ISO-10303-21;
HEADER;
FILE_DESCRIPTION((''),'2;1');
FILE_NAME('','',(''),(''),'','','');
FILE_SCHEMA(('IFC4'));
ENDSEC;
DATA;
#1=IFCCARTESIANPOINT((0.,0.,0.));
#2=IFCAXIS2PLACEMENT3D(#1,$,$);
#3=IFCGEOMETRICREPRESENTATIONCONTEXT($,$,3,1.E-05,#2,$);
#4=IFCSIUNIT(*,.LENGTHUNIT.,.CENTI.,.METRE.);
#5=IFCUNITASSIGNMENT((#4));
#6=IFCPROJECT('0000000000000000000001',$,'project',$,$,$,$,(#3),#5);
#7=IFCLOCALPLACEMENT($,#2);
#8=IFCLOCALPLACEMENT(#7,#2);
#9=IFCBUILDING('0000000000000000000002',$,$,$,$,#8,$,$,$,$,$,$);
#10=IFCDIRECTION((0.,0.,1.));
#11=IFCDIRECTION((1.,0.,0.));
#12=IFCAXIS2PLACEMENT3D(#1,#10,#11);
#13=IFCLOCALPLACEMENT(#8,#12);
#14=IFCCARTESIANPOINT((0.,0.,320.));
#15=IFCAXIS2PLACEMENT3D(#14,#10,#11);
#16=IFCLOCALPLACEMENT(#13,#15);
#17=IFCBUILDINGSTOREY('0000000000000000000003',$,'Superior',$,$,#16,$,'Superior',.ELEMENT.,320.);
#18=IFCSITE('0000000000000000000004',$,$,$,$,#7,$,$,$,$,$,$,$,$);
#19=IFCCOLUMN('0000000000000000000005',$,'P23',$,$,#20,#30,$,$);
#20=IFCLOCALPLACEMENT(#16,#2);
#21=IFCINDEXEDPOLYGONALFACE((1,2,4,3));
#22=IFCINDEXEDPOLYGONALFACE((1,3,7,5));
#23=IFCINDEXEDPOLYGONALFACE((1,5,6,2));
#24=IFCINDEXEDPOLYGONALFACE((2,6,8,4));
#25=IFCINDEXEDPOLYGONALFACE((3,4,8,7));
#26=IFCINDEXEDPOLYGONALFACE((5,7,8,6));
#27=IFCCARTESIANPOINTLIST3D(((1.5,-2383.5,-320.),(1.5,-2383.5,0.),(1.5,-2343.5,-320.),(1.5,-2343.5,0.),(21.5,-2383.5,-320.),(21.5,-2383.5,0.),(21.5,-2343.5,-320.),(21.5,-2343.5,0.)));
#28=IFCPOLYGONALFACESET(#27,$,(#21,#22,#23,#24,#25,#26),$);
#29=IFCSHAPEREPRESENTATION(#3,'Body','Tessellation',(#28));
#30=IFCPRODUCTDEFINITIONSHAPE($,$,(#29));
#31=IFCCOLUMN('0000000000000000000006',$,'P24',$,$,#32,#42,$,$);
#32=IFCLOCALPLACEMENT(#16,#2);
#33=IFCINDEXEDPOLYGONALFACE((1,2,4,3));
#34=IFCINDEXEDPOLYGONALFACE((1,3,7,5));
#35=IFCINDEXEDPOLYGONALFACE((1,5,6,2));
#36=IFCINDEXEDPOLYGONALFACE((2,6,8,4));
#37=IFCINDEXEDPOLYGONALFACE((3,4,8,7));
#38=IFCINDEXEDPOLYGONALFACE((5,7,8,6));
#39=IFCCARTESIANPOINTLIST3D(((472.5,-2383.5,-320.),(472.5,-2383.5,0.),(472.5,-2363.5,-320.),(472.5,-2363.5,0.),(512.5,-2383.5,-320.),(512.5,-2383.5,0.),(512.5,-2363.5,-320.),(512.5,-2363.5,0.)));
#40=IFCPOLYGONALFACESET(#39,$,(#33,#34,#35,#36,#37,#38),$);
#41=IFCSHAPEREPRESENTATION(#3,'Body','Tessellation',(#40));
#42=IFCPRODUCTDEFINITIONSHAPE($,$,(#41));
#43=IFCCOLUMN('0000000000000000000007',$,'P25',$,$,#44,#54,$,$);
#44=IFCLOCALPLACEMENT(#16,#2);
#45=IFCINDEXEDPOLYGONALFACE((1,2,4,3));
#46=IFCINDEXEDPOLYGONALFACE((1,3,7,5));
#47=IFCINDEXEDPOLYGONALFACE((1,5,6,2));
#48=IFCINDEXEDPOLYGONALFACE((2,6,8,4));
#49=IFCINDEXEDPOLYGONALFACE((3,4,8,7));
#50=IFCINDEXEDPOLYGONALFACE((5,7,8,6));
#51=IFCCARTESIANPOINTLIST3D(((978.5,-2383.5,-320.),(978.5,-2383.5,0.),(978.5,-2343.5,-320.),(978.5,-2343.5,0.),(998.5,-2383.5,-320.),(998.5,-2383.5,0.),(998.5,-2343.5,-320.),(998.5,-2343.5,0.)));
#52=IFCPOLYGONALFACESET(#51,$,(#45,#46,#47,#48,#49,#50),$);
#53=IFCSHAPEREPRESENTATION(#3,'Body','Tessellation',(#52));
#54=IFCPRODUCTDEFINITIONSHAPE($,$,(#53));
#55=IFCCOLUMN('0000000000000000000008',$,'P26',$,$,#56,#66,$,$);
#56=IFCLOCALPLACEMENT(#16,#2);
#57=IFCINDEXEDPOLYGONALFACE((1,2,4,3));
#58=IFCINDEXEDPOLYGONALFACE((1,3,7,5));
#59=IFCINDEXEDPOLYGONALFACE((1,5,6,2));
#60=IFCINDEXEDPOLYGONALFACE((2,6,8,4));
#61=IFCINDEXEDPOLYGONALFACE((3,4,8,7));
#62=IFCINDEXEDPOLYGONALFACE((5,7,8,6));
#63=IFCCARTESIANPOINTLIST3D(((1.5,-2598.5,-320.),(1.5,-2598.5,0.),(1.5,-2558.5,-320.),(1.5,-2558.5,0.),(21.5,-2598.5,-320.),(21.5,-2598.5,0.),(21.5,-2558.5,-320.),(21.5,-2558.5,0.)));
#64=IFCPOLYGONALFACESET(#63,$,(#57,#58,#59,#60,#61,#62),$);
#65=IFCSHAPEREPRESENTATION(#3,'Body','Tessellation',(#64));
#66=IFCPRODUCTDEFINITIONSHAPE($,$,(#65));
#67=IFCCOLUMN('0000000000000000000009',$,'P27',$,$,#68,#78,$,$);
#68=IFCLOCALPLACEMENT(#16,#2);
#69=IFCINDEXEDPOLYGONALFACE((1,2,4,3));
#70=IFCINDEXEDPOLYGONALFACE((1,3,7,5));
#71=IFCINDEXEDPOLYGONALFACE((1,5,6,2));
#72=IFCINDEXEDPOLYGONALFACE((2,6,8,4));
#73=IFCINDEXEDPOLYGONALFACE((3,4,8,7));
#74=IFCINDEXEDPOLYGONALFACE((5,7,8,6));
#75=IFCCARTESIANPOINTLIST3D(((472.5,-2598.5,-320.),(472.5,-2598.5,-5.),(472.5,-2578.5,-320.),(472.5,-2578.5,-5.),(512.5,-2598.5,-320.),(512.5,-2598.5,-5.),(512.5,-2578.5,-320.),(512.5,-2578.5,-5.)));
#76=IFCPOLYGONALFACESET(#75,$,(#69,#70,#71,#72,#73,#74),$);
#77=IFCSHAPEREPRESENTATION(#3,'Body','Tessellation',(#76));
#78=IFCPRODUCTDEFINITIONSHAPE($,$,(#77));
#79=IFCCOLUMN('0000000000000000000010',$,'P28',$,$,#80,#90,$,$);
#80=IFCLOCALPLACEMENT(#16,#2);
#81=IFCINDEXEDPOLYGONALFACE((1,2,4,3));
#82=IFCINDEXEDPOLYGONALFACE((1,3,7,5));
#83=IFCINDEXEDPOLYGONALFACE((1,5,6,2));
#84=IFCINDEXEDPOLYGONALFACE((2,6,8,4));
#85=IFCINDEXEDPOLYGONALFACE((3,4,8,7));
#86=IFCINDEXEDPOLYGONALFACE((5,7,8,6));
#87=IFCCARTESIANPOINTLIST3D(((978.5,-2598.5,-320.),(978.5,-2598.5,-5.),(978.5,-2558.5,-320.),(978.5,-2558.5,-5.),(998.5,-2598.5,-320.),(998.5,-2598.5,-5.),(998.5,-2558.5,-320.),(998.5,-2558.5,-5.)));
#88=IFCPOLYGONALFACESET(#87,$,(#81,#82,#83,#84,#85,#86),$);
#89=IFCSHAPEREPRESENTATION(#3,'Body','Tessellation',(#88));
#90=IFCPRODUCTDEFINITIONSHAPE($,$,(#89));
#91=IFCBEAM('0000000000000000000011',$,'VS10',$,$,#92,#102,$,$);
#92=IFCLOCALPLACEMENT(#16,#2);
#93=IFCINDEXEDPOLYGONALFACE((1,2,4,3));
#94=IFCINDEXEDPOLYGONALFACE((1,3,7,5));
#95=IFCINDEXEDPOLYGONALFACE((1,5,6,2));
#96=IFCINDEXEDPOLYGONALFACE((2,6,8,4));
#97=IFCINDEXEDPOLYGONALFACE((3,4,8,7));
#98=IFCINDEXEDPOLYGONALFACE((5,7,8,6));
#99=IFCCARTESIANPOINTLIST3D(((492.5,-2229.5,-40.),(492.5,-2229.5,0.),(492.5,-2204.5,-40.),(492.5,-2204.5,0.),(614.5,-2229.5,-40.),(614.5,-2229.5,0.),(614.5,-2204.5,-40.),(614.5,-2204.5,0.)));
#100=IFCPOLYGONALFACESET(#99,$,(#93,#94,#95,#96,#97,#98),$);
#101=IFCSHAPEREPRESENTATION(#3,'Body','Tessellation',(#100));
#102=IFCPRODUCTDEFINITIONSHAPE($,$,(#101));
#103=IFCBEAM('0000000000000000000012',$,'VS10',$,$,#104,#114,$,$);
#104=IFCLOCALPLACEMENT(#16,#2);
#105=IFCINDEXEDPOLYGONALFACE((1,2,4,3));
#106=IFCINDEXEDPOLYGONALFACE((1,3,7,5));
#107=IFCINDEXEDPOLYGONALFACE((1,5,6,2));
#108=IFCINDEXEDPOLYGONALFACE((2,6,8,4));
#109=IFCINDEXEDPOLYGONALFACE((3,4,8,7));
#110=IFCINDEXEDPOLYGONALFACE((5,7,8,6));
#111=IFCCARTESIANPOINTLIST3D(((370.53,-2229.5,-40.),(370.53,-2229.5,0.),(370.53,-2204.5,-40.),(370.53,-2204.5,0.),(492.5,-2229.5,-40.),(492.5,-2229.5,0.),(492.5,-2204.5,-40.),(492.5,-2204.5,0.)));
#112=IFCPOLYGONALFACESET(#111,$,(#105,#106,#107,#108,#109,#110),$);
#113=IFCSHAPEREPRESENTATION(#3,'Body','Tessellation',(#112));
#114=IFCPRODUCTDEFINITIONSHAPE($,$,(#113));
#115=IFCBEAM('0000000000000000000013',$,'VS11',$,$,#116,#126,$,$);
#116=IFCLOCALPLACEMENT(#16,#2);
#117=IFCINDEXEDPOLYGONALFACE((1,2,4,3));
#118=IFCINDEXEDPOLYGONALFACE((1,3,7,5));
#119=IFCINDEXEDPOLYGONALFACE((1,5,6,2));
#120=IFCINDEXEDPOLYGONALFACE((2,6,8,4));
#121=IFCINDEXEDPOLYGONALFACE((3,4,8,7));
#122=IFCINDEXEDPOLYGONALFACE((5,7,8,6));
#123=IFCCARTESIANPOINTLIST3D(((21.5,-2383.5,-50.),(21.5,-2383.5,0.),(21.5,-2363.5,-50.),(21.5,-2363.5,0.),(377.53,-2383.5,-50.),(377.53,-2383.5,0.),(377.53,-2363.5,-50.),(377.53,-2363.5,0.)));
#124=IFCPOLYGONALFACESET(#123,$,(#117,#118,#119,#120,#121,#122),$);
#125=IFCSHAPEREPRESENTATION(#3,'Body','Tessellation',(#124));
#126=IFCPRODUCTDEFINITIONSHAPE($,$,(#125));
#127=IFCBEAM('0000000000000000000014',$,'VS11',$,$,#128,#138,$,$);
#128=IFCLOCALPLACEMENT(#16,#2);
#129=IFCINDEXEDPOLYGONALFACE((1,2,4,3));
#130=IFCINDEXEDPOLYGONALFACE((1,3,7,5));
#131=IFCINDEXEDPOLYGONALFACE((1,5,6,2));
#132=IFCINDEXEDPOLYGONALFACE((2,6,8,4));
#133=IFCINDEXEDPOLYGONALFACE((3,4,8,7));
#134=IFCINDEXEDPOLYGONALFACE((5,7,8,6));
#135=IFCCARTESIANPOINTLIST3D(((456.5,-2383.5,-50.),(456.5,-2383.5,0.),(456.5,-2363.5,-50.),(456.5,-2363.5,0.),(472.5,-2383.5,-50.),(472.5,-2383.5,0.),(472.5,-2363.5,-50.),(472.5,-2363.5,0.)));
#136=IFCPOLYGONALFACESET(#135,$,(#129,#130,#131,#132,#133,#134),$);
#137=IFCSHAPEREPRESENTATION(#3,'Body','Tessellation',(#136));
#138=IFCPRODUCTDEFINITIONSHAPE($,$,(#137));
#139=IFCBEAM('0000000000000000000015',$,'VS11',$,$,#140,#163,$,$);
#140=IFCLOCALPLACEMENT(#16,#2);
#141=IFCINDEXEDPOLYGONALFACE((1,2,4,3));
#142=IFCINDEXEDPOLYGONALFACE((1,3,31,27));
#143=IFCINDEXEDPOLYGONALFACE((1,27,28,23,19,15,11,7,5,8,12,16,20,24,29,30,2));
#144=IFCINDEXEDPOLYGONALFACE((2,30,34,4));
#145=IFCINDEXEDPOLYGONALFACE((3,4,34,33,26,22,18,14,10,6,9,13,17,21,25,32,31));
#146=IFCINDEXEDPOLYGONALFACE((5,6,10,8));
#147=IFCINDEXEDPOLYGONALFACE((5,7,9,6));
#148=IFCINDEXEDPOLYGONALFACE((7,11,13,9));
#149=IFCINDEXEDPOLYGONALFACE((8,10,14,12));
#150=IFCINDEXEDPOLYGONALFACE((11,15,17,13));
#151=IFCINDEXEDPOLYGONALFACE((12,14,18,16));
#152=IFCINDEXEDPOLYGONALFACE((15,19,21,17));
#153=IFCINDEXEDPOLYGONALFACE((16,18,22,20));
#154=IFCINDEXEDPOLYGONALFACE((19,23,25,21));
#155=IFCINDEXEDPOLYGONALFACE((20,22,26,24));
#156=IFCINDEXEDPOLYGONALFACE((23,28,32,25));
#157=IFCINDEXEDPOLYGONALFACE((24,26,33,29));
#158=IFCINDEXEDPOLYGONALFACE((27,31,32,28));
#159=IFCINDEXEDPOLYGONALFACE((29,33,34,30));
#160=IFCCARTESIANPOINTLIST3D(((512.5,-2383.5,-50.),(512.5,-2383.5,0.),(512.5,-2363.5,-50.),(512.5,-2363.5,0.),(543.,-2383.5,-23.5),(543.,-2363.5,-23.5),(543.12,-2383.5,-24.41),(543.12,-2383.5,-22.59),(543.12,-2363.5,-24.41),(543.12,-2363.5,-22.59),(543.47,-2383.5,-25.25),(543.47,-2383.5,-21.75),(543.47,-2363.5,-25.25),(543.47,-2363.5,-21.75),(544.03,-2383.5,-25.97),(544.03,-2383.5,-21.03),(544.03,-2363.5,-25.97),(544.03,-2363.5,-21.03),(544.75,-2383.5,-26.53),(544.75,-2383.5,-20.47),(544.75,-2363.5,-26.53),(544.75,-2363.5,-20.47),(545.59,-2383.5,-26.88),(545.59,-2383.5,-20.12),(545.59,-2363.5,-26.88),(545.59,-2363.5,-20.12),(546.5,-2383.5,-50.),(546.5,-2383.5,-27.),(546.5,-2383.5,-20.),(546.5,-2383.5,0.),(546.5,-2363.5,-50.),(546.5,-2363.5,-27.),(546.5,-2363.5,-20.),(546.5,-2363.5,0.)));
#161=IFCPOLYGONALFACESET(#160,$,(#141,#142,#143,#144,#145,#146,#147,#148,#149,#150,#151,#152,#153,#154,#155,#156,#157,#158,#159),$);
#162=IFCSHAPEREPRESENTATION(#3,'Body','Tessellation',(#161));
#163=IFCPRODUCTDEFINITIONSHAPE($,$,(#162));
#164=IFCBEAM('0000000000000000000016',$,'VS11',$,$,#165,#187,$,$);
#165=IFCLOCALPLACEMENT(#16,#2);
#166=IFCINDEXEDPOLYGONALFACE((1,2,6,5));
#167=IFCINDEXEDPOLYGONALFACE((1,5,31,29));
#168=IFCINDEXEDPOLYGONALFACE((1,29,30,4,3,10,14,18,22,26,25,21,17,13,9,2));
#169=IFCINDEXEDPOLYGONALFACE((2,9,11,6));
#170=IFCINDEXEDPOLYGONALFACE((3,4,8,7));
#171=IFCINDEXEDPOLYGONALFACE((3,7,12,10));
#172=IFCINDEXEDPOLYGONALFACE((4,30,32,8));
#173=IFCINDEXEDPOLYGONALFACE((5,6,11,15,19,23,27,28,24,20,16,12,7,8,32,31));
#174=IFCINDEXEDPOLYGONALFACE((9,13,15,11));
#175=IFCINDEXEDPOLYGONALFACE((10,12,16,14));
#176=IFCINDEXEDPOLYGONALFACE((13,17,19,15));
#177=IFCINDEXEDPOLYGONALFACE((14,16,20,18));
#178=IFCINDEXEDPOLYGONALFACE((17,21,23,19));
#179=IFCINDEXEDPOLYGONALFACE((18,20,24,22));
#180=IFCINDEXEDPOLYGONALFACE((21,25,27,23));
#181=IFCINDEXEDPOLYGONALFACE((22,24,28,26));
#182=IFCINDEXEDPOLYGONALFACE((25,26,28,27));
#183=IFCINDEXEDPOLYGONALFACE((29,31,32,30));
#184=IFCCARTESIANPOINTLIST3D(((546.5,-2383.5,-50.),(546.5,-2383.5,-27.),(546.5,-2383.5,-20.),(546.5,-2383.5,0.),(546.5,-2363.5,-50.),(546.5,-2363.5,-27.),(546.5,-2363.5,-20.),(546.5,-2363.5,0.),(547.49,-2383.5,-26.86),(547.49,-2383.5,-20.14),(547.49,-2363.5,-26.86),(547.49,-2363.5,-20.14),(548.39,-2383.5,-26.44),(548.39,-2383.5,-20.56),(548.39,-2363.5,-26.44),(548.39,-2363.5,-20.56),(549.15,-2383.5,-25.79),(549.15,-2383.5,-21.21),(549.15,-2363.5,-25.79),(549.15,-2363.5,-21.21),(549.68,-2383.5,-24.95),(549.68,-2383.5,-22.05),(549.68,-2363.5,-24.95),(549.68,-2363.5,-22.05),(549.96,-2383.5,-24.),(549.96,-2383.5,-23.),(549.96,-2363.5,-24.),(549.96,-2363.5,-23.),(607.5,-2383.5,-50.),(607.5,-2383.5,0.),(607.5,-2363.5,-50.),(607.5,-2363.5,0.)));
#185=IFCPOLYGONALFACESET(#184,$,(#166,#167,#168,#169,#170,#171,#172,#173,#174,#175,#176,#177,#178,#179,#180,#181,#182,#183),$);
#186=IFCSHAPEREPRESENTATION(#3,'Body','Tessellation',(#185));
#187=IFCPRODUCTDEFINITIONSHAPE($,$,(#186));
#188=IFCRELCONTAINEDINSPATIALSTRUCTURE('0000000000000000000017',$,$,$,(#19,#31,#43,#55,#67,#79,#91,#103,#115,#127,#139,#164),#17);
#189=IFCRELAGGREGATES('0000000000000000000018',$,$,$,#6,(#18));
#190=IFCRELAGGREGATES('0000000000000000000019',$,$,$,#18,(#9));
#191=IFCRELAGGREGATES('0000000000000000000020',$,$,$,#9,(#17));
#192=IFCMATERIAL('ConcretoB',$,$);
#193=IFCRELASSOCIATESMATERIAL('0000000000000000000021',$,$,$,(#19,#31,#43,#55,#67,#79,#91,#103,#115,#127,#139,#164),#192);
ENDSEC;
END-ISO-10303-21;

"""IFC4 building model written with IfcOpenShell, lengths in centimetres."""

from ifc_helpers import new_model, si_unit, frame, origin, origin_with_axes, origin_2d_with_axis, place, context, project, spatial, polyline, circle, outline, extrude, material, element, save


model = new_model("IFC4")

# Units and contexts
context_of_model = context(None, 3, precision=1e-05, world=origin())
ifc_project = project(units=[si_unit("LENGTHUNIT", "METRE", prefix="CENTI")], contexts=[context_of_model])

# Site, building, storey
site_placement = place(None, origin())
site = spatial("IfcSite", under=ifc_project, at=site_placement)
building_placement = place(site_placement, origin())
building = spatial("IfcBuilding", under=site, at=building_placement)
placement = place(building_placement, origin_with_axes())
storey_placement = place(placement, frame((0.0, 0.0, 320.0), z_axis=(0.0, 0.0, 1.0), x_axis=(1.0, 0.0, 0.0)))
storey = spatial("IfcBuildingStorey", under=building, at=storey_placement, Name="Superior", LongName="Superior", CompositionType="ELEMENT", Elevation=320.0)

# Columns
ifc_material = material(Name="ConcretoB")
column_1_placement = place(storey_placement, frame((11.5, -2363.5, 0.0), z_axis=(0.0, 0.0, 1.0), x_axis=(1.0, 0.0, 0.0)))
element("IfcColumn", 1, at=column_1_placement, inside=storey, material=ifc_material, Name="P23", context=context_of_model, shape_type="SolidModel", body=[
    extrude(outline(polyline([(-10.0, -20.0), (10.0, -20.0), (10.0, 20.0), (-10.0, 20.0), (-10.0, -20.0)])), frame((0.0, 0.0, 0.0), z_axis=(0.0, 0.0, 1.0), x_axis=(1.0, 0.0, 0.0)), (0.0, 0.0, -1.0), 320.0),
])
column_2_placement = place(storey_placement, frame((492.5, -2373.5, 0.0), z_axis=(0.0, 0.0, 1.0), x_axis=(1.0, 0.0, 0.0)))
element("IfcColumn", 2, at=column_2_placement, inside=storey, material=ifc_material, Name="P24", context=context_of_model, shape_type="SolidModel", body=[
    extrude(outline(polyline([(-20.0, 10.0), (-20.0, -10.0), (20.0, -10.0), (20.0, 10.0), (-20.0, 10.0)])), origin_with_axes(), (0.0, 0.0, -1.0), 320.0),
])
column_3_placement = place(storey_placement, frame((988.5, -2363.5, 0.0), z_axis=(0.0, 0.0, 1.0), x_axis=(1.0, 0.0, 0.0)))
element("IfcColumn", 3, at=column_3_placement, inside=storey, material=ifc_material, Name="P25", context=context_of_model, shape_type="SolidModel", body=[
    extrude(outline(polyline([(10.0, 20.0), (-10.0, 20.0), (-10.0, -20.0), (10.0, -20.0), (10.0, 20.0)])), origin_with_axes(), (0.0, 0.0, -1.0), 320.0),
])
column_4_placement = place(storey_placement, frame((11.5, -2578.5, 0.0), z_axis=(0.0, 0.0, 1.0), x_axis=(1.0, 0.0, 0.0)))
element("IfcColumn", 4, at=column_4_placement, inside=storey, material=ifc_material, Name="P26", context=context_of_model, shape_type="SolidModel", body=[
    extrude(outline(polyline([(-10.0, -20.0), (10.0, -20.0), (10.0, 20.0), (-10.0, 20.0), (-10.0, -20.0)])), frame((0.0, 0.0, 0.0), z_axis=(0.0, 0.0, 1.0), x_axis=(1.0, 0.0, 0.0)), (0.0, 0.0, -1.0), 320.0),
])
column_5_placement = place(storey_placement, frame((492.5, -2588.5, -5.0), z_axis=(0.0, 0.0, 1.0), x_axis=(1.0, 0.0, 0.0)))
element("IfcColumn", 5, at=column_5_placement, inside=storey, material=ifc_material, Name="P27", context=context_of_model, shape_type="SolidModel", body=[
    extrude(outline(polyline([(20.0, -10.0), (20.0, 10.0), (-20.0, 10.0), (-20.0, -10.0), (20.0, -10.0)])), origin_with_axes(), (0.0, 0.0, -1.0), 315.0),
])
column_6_placement = place(storey_placement, frame((988.5, -2578.5, -5.0), z_axis=(0.0, 0.0, 1.0), x_axis=(1.0, 0.0, 0.0)))
element("IfcColumn", 6, at=column_6_placement, inside=storey, material=ifc_material, Name="P28", context=context_of_model, shape_type="SolidModel", body=[
    extrude(outline(polyline([(10.0, 20.0), (-10.0, 20.0), (-10.0, -20.0), (10.0, -20.0), (10.0, 20.0)])), origin_with_axes(), (0.0, 0.0, -1.0), 315.0),
])

# Beams
beam_1_placement = place(storey_placement, frame((553.5, -2217.0, 0.0), z_axis=(0.0, 0.0, 1.0), x_axis=(1.0, 0.0, 0.0)))
element("IfcBeam", 7, at=beam_1_placement, inside=storey, material=ifc_material, Name="VS10", context=context_of_model, shape_type="SolidModel", body=[
    extrude(outline(polyline([(-12.5, -20.0), (12.5, -20.0), (12.5, 20.0), (-12.5, 20.0), (-12.5, -20.0)])), frame((-61.0, 0.0, -20.0), z_axis=(1.0, 0.0, 0.0), x_axis=(0.0, -1.0, 0.0)), (0.0, 0.0, 1.0), 122.0),
])
beam_2_placement = place(storey_placement, frame((431.51, -2217.0, 0.0), z_axis=(0.0, 0.0, 1.0), x_axis=(1.0, 0.0, 0.0)))
element("IfcBeam", 8, at=beam_2_placement, inside=storey, material=ifc_material, Name="VS10", context=context_of_model, shape_type="SolidModel", body=[
    extrude(outline(polyline([(-12.5, -20.0), (12.5, -20.0), (12.5, 20.0), (-12.5, 20.0), (-12.5, -20.0)])), frame((-60.98, 0.0, -20.0), z_axis=(1.0, 0.0, 0.0), x_axis=(0.0, -1.0, 0.0)), (0.0, 0.0, 1.0), 121.97),
])
beam_3_placement = place(storey_placement, frame((199.51, -2373.5, 0.0), z_axis=(0.0, 0.0, 1.0), x_axis=(1.0, 0.0, 0.0)))
element("IfcBeam", 9, at=beam_3_placement, inside=storey, material=ifc_material, Name="VS11", context=context_of_model, shape_type="SolidModel", body=[
    extrude(outline(polyline([(-10.0, -25.0), (10.0, -25.0), (10.0, 25.0), (-10.0, 25.0), (-10.0, -25.0)])), frame((-178.01, 0.0, -25.0), z_axis=(1.0, 0.0, 0.0), x_axis=(0.0, -1.0, 0.0)), (0.0, 0.0, 1.0), 356.03),
])
beam_4_placement = place(storey_placement, frame((464.5, -2373.5, 0.0), z_axis=(0.0, 0.0, 1.0), x_axis=(1.0, 0.0, 0.0)))
element("IfcBeam", 10, at=beam_4_placement, inside=storey, material=ifc_material, Name="VS11", context=context_of_model, shape_type="SolidModel", body=[
    extrude(outline(polyline([(-10.0, -25.0), (10.0, -25.0), (10.0, 25.0), (-10.0, 25.0), (-10.0, -25.0)])), frame((-8.0, 0.0, -25.0), z_axis=(1.0, 0.0, 0.0), x_axis=(0.0, -1.0, 0.0)), (0.0, 0.0, 1.0), 16.0),
])

# Beams, openings
beam_5_placement = place(storey_placement, frame((529.5, -2373.5, 0.0), z_axis=(0.0, 0.0, 1.0), x_axis=(1.0, 0.0, 0.0)))
beam_5 = element("IfcBeam", 11, at=beam_5_placement, inside=storey, material=ifc_material, Name="VS11", context=context_of_model, shape_type="SolidModel", body=[
    extrude(outline(polyline([(-10.0, -25.0), (10.0, -25.0), (10.0, 25.0), (-10.0, 25.0), (-10.0, -25.0)])), frame((-17.0, 0.0, -25.0), z_axis=(1.0, 0.0, 0.0), x_axis=(0.0, -1.0, 0.0)), (0.0, 0.0, 1.0), 34.0),
])
opening_1_placement = place(storey_placement, frame((0.0, 0.0, -320.0), z_axis=(0.0, 0.0, 1.0), x_axis=(1.0, 0.0, 0.0)))
element("IfcOpeningElement", 12, at=opening_1_placement, cuts=beam_5, material=ifc_material, context=context_of_model, shape_type="SweptSolid", body=[
    extrude(circle(Radius=3.5, at=origin_2d_with_axis()), frame((546.5, -2383.5, 296.5), z_axis=(0.0, 1.0, 0.0), x_axis=(-1.0, 0.0, 0.0)), (0.0, 0.0, 1.0), 20.0),
])
beam_6_placement = place(storey_placement, frame((577.0, -2373.5, 0.0), z_axis=(0.0, 0.0, 1.0), x_axis=(1.0, 0.0, 0.0)))
beam_6 = element("IfcBeam", 13, at=beam_6_placement, inside=storey, material=ifc_material, Name="VS11", context=context_of_model, shape_type="SolidModel", body=[
    extrude(outline(polyline([(-10.0, -25.0), (10.0, -25.0), (10.0, 25.0), (-10.0, 25.0), (-10.0, -25.0)])), frame((-30.5, 0.0, -25.0), z_axis=(1.0, 0.0, 0.0), x_axis=(0.0, -1.0, 0.0)), (0.0, 0.0, 1.0), 61.0),
])
opening_2_placement = place(storey_placement, frame((0.0, 0.0, -320.0), z_axis=(0.0, 0.0, 1.0), x_axis=(1.0, 0.0, 0.0)))
element("IfcOpeningElement", 14, at=opening_2_placement, cuts=beam_6, material=ifc_material, context=context_of_model, shape_type="SweptSolid", body=[
    extrude(circle(Radius=3.5, at=origin_2d_with_axis()), frame((546.5, -2383.5, 296.5), z_axis=(0.0, 1.0, 0.0), x_axis=(-1.0, 0.0, 0.0)), (0.0, 0.0, 1.0), 20.0),
])

save(model, "model.ifc")
